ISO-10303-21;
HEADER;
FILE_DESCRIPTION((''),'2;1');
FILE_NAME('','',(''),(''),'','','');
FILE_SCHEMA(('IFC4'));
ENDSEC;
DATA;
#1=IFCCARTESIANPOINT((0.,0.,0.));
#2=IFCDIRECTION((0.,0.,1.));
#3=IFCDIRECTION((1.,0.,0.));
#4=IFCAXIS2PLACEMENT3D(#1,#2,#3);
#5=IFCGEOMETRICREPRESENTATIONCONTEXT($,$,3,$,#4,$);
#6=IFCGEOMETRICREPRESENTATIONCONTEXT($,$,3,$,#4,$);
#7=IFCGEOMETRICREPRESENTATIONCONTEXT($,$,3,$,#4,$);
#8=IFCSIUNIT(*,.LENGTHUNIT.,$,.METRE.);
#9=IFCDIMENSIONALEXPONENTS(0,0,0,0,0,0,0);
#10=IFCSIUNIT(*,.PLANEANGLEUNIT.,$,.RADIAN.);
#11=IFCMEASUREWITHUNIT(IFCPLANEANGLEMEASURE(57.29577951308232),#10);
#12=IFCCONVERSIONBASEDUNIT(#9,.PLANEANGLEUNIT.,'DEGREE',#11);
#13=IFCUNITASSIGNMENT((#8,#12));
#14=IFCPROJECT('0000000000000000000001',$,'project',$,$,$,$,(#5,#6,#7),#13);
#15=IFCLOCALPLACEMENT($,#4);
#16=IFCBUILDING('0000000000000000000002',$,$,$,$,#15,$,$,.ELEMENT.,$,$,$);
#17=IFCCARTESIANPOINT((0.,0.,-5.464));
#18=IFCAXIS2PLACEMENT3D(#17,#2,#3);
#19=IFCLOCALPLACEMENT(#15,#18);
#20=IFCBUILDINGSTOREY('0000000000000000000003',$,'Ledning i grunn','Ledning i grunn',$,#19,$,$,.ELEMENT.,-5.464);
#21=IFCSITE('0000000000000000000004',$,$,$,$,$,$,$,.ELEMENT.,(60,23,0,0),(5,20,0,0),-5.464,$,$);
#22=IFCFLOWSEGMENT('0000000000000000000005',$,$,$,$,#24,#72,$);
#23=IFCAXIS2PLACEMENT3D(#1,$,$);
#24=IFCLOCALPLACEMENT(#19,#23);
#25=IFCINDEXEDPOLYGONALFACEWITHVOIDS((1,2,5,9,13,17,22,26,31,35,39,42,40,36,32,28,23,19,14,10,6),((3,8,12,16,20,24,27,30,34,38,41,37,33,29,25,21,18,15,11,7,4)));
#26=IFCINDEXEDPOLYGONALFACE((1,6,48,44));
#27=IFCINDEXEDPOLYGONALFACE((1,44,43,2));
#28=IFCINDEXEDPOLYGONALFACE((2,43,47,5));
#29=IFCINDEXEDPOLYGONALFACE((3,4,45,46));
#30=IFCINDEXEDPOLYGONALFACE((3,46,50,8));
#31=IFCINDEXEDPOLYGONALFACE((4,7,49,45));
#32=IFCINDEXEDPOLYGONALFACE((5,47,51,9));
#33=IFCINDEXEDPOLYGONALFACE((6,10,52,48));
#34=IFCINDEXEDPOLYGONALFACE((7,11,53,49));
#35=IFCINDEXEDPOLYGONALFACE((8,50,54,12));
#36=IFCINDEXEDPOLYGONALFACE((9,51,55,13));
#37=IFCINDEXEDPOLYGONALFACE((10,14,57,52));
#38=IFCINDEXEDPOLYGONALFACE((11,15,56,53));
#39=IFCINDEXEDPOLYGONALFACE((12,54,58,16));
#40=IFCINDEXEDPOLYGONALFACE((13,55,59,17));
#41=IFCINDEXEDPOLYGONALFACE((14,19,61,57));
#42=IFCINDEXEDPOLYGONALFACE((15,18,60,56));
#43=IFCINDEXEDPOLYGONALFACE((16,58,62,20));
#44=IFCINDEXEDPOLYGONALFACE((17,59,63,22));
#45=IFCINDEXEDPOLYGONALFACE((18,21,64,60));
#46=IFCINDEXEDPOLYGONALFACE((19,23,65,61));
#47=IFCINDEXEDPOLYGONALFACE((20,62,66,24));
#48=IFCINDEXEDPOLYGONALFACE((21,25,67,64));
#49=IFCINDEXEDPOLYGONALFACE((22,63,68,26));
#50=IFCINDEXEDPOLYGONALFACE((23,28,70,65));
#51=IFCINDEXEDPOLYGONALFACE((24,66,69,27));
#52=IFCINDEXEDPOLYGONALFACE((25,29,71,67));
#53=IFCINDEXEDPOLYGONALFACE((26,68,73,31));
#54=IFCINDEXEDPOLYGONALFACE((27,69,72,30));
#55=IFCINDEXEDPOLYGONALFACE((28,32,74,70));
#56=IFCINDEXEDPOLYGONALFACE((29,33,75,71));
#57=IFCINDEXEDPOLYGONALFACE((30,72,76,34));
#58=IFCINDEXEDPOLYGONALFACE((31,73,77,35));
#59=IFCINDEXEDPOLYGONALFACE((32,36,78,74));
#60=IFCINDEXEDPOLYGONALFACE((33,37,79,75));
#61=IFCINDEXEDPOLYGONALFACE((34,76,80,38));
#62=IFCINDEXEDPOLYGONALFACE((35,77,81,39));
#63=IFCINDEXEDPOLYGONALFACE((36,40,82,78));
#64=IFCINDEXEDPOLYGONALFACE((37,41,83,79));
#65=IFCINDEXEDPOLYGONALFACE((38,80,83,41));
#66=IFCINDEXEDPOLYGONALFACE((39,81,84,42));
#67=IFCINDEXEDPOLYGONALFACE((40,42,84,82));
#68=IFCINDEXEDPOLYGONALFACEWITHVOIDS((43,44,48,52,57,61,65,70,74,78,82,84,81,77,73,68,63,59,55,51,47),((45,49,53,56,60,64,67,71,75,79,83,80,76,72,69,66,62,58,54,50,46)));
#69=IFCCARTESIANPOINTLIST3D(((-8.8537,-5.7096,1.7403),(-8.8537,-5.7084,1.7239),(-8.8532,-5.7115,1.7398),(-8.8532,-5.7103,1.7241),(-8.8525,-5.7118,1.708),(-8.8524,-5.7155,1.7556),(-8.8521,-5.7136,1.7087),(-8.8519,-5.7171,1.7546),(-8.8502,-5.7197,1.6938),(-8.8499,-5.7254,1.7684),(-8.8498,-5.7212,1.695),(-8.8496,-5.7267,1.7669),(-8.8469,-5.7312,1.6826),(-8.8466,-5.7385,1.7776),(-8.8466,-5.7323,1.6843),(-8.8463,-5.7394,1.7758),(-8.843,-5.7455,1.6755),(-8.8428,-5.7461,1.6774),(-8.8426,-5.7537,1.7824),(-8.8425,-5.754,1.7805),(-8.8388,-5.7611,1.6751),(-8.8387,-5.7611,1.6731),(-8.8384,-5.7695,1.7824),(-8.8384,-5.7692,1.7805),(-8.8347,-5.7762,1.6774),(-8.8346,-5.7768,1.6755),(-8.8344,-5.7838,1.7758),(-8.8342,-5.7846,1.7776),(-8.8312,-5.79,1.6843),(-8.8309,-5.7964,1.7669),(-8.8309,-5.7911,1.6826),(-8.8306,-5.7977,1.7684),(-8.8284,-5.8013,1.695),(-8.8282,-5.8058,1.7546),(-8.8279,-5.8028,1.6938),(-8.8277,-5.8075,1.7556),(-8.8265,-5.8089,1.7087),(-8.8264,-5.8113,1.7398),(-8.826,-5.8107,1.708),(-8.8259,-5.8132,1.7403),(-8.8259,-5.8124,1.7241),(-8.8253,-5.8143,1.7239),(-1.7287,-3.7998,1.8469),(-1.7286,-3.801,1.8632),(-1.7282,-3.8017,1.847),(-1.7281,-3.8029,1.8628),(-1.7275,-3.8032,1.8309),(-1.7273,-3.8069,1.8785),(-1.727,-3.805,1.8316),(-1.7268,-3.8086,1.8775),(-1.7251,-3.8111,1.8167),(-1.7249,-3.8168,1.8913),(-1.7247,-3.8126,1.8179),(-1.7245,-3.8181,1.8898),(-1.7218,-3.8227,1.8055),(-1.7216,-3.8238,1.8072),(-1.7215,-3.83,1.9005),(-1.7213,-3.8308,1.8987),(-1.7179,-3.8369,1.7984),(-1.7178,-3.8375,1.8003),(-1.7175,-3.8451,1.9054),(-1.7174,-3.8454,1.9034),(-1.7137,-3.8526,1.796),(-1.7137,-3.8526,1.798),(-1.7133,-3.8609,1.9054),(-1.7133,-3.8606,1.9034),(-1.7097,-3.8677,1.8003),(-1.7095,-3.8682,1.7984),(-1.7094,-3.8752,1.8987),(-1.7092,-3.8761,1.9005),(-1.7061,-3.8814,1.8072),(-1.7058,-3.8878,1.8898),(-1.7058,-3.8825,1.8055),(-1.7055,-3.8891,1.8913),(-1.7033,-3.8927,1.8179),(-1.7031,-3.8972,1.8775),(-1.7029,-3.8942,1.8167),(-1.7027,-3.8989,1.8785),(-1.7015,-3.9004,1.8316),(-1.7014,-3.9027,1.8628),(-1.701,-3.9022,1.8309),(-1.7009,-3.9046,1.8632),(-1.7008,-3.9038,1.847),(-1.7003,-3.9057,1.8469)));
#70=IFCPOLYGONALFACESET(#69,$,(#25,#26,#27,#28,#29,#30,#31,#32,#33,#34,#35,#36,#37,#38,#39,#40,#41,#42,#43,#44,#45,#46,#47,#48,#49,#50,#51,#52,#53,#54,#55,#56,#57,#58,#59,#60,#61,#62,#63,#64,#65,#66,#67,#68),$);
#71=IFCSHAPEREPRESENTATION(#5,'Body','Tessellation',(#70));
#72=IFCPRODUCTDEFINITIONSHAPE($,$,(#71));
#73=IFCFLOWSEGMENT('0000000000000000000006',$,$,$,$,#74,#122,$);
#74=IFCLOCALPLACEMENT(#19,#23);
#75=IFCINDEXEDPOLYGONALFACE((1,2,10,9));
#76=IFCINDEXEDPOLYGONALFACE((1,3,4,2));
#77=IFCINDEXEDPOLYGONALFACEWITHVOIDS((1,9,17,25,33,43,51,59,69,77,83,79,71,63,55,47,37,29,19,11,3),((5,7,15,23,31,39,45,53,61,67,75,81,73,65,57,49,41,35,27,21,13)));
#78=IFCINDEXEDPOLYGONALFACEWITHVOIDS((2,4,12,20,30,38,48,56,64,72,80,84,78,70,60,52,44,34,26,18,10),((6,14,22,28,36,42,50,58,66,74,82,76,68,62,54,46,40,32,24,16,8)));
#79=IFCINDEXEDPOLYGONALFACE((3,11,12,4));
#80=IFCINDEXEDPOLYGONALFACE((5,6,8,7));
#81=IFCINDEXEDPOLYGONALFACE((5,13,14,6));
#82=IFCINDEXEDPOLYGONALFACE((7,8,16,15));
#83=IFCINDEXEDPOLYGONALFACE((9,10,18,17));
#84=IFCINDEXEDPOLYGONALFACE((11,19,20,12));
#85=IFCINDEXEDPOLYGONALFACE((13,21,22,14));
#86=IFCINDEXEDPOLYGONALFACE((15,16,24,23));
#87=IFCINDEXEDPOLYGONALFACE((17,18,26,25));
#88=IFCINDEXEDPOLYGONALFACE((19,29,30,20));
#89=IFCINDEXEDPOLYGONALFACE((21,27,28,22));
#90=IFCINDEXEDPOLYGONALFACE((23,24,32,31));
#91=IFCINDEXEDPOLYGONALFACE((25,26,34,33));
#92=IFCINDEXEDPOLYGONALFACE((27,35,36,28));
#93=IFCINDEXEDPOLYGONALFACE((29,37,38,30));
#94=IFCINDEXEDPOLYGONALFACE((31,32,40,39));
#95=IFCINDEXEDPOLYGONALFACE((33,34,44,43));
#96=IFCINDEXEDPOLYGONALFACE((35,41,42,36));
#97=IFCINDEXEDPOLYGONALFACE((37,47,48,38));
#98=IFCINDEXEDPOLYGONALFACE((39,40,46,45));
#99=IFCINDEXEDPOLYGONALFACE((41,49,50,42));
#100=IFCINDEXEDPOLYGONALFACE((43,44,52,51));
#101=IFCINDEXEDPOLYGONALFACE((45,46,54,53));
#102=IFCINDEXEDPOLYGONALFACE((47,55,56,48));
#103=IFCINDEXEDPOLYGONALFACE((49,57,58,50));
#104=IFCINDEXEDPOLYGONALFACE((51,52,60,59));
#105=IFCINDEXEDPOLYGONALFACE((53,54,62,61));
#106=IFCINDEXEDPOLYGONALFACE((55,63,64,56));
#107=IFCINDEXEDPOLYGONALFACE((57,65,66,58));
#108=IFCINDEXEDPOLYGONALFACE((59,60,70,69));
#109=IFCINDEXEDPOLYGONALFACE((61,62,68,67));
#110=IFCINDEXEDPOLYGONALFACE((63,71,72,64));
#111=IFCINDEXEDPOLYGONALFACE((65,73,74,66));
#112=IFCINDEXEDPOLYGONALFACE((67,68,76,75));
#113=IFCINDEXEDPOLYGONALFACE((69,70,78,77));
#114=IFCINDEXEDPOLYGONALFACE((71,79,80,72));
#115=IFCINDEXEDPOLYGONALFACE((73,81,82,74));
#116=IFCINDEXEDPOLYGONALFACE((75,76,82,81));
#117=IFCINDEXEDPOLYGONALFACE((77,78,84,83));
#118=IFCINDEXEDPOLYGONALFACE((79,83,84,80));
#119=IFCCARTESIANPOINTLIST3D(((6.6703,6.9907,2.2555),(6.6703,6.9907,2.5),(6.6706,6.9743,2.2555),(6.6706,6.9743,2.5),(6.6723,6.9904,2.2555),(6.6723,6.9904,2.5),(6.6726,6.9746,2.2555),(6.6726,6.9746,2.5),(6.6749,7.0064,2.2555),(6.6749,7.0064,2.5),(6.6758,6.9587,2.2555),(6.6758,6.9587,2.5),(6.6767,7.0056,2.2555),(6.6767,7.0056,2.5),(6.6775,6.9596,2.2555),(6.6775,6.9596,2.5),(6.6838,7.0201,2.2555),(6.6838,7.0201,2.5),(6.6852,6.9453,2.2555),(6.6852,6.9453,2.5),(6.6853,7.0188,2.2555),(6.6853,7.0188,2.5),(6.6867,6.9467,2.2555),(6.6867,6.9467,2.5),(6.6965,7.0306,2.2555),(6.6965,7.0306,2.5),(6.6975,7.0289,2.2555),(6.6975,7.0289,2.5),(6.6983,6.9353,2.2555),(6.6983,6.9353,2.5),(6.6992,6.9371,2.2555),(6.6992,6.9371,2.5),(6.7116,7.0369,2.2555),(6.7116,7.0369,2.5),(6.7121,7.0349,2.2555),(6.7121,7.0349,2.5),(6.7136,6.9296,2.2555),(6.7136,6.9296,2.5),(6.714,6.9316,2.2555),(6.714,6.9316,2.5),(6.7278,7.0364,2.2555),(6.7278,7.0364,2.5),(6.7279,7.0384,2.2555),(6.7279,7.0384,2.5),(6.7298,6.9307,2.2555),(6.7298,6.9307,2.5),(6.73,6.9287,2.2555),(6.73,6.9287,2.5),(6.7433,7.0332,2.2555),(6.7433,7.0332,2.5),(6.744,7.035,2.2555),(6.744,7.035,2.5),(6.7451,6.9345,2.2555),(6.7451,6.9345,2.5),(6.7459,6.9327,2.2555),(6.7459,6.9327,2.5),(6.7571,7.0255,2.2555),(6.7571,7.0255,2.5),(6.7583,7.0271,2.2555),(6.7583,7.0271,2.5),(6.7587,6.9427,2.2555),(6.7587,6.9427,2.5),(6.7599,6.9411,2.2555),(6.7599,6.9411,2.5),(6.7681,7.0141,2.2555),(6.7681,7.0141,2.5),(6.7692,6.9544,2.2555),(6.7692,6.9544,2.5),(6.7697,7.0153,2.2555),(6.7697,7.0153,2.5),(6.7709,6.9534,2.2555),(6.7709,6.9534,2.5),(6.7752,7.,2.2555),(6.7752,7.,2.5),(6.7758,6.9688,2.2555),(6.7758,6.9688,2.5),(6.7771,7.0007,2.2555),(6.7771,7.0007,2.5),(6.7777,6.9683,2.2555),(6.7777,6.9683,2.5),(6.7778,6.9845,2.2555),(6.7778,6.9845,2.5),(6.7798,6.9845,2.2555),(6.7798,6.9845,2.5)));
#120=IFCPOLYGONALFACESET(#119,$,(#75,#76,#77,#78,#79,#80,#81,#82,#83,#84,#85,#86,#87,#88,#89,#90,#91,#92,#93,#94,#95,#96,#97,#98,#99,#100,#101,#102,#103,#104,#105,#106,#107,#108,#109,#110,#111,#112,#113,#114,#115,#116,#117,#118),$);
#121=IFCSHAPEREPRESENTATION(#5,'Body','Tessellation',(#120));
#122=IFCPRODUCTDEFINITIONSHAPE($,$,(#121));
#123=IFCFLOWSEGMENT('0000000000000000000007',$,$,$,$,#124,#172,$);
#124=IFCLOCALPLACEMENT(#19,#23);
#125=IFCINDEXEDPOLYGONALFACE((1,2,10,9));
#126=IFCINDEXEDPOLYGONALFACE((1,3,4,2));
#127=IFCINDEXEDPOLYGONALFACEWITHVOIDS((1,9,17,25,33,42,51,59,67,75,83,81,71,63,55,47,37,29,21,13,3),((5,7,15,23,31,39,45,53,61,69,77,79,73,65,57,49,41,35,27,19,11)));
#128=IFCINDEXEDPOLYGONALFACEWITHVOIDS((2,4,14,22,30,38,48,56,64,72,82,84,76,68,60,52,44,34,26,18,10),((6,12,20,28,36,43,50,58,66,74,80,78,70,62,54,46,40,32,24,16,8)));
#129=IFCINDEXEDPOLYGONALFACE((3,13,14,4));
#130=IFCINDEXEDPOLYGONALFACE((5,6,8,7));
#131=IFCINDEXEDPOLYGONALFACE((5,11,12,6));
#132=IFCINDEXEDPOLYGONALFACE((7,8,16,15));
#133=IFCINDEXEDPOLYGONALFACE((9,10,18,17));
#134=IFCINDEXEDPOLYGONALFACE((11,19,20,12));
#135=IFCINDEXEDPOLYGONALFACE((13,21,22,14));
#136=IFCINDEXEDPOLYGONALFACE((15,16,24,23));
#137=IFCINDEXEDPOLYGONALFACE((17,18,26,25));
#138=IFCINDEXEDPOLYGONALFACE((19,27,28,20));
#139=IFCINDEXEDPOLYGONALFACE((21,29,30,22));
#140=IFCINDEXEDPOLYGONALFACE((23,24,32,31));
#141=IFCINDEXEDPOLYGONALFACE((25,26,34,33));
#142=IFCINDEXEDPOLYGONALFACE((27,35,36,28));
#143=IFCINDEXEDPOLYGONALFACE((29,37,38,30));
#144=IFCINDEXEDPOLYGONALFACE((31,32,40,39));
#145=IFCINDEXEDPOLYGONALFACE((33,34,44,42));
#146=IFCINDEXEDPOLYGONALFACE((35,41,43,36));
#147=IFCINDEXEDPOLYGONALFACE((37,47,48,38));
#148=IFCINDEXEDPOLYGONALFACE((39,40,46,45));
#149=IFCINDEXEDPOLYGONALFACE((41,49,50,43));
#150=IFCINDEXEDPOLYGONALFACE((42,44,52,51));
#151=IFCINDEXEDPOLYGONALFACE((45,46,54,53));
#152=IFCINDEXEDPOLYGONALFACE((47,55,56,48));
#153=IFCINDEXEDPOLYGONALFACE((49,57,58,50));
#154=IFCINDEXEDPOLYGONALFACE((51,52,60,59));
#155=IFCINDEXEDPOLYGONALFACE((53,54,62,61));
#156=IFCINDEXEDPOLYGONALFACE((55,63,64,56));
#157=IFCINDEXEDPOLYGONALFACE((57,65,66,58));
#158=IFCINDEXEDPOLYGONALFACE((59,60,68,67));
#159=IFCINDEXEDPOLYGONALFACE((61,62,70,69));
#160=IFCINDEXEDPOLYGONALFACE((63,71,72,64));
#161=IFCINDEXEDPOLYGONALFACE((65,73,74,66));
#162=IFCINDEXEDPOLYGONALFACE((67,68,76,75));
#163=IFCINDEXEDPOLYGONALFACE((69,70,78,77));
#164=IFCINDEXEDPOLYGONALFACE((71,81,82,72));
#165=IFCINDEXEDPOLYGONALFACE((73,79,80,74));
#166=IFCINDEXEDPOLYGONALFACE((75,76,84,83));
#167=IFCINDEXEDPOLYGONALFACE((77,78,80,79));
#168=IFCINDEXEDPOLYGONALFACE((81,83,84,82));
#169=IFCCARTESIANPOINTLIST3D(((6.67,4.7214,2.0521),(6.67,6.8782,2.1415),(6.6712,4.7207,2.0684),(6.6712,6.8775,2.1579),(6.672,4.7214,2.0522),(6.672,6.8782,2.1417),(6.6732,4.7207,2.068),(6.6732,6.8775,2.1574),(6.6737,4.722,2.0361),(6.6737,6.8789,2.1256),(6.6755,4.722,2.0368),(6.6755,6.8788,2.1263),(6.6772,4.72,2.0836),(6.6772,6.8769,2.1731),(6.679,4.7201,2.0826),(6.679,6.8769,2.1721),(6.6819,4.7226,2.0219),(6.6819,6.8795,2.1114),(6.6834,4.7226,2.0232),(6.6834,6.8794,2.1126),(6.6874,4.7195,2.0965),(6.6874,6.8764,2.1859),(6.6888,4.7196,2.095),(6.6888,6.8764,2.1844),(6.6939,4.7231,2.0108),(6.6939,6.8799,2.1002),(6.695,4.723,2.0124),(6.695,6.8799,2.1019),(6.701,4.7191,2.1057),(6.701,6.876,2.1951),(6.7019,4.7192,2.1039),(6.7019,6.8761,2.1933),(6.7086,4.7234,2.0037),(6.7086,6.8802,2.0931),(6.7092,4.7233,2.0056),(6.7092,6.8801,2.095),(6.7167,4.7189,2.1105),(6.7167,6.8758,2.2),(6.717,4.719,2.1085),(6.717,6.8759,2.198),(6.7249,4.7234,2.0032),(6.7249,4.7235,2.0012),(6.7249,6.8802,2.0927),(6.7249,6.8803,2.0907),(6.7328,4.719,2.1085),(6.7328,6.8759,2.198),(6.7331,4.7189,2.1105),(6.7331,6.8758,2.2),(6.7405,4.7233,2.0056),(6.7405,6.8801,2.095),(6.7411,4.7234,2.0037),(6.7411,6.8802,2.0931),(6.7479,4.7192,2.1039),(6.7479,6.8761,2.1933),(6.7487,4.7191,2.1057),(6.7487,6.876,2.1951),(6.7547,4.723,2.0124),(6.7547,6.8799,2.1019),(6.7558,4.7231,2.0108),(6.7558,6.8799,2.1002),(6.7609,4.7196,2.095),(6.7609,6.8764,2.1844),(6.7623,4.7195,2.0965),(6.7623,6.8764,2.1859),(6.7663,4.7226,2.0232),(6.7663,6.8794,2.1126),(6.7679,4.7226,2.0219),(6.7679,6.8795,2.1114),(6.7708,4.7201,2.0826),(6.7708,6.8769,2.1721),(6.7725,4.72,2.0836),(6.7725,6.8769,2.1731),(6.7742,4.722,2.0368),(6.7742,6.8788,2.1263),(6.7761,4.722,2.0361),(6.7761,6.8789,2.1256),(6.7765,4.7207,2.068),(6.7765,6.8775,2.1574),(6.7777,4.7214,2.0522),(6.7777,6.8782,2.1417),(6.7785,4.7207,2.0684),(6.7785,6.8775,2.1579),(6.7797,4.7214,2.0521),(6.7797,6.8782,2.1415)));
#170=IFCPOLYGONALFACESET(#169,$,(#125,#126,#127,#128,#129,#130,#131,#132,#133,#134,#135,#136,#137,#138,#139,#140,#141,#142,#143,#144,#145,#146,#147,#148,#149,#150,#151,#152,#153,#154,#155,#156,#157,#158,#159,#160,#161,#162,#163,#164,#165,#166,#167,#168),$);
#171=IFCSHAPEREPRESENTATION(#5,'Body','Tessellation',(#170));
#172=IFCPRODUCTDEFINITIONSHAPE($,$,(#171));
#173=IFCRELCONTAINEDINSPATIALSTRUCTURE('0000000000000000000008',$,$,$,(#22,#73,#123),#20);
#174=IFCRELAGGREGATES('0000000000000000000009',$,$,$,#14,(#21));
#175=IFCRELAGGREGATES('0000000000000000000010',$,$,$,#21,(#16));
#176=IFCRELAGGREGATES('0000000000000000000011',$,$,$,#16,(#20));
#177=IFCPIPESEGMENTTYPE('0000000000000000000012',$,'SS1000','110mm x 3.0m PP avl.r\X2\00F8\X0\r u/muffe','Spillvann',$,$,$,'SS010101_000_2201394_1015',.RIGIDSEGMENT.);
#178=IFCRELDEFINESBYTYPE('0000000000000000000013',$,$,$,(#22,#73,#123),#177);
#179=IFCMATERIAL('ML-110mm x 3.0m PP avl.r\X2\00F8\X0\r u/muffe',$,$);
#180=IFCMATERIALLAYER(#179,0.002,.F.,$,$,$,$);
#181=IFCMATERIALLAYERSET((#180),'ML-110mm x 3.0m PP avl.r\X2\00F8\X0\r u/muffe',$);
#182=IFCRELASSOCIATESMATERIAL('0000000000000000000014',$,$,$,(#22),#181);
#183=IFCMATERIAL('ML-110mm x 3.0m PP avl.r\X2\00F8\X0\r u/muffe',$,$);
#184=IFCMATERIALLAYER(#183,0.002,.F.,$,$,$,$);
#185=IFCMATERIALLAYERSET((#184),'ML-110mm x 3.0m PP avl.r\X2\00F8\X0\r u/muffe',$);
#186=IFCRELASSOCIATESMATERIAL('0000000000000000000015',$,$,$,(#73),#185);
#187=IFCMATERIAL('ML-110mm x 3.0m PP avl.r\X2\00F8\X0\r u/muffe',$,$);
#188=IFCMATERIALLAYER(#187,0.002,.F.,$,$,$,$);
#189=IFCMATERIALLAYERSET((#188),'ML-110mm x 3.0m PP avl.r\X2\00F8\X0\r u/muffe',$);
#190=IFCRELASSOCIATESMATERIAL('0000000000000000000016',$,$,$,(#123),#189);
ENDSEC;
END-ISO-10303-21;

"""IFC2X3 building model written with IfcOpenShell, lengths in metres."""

from ifc_helpers import new_model, entity, si_unit, converted_unit, frame, origin_with_axes, origin_2d_with_axis, place, context, project, spatial, hollow_circle, extrude, material, layer, layer_set, layer_usage, type_object, element, save


model = new_model("IFC2X3")

# Units and contexts
context_of_model_1 = context(None, 3, world=origin_with_axes())
context_of_model_2 = context(None, 3, world=origin_with_axes())
context_of_model_3 = context(None, 3, world=origin_with_axes())
ifc_project = project(units=[si_unit("LENGTHUNIT", "METRE"), converted_unit("PLANEANGLEUNIT", "DEGREE", entity("IfcPlaneAngleMeasure", 57.29577951308232), si_unit("PLANEANGLEUNIT", "RADIAN"), dimensions=[0, 0, 0, 0, 0, 0, 0])], contexts=[context_of_model_1, context_of_model_2, context_of_model_3])

# Site, building, storey
site = spatial("IfcSite", under=ifc_project, CompositionType="ELEMENT", RefLatitude=(60, 23, 0, 0), RefLongitude=(5, 20, 0, 0), RefElevation=-5.464)
building_placement = place(None, origin_with_axes())
building = spatial("IfcBuilding", under=site, at=building_placement, CompositionType="ELEMENT")
storey_placement = place(building_placement, frame((0.0, 0.0, -5.464), z_axis=(0.0, 0.0, 1.0), x_axis=(1.0, 0.0, 0.0)))
storey = spatial("IfcBuildingStorey", under=building, at=storey_placement, Name="Ledning i grunn", Description="Ledning i grunn", CompositionType="ELEMENT", Elevation=-5.464)

# Flow segments
pipe_segment_type_1 = type_object("IfcPipeSegmentType", Name="SS1000", Description="110mm x 3.0m PP avl.rør u/muffe", ApplicableOccurrence="Spillvann", ElementType="SS010101_000_2201394_1015", PredefinedType="RIGIDSEGMENT")
ifc_material_1 = material(Name="ML-110mm x 3.0m PP avl.rør u/muffe")
ifc_layer_1 = layer(ifc_material_1, 0.002, ventilated=False)
ifc_layer_set_1 = layer_set([ifc_layer_1], Name="ML-110mm x 3.0m PP avl.rør u/muffe")
ifc_layer_usage_1 = layer_usage(ifc_layer_set_1, "AXIS2", "POSITIVE", 0.0)
flow_segment_1_placement = place(storey_placement, frame((-1.7145, -3.8528, 1.851), z_axis=(-0.965811, -0.258711, -0.016661), x_axis=(0.016094, 0.004311, -0.999861)))
element("IfcFlowSegment", 1, at=flow_segment_1_placement, inside=storey, type_object=pipe_segment_type_1, material=ifc_layer_usage_1, context=context_of_model_1, shape_type="SweptSolid", body=[
    extrude(hollow_circle(Radius=0.055, WallThickness=0.002, at=origin_2d_with_axis()), origin_with_axes(), (0.0, 0.0, 1.0), 7.3773),
])
ifc_material_2 = material(Name="ML-110mm x 3.0m PP avl.rør u/muffe")
ifc_layer_2 = layer(ifc_material_2, 0.002, ventilated=False)
ifc_layer_set_2 = layer_set([ifc_layer_2], Name="ML-110mm x 3.0m PP avl.rør u/muffe")
ifc_layer_usage_2 = layer_usage(ifc_layer_set_2, "AXIS2", "POSITIVE", 0.0)
flow_segment_2_placement = place(storey_placement, frame((6.7249, 6.9835, 2.5), z_axis=(0.0, 0.0, -1.0), x_axis=(0.382683, -0.92388, 0.0)))
element("IfcFlowSegment", 2, at=flow_segment_2_placement, inside=storey, type_object=pipe_segment_type_1, material=ifc_layer_usage_2, context=context_of_model_1, shape_type="SweptSolid", body=[
    extrude(hollow_circle(Radius=0.055, WallThickness=0.002, at=origin_2d_with_axis()), origin_with_axes(), (0.0, 0.0, 1.0), 0.2445),
])
ifc_material_3 = material(Name="ML-110mm x 3.0m PP avl.rør u/muffe")
ifc_layer_3 = layer(ifc_material_3, 0.002, ventilated=False)
ifc_layer_set_3 = layer_set([ifc_layer_3], Name="ML-110mm x 3.0m PP avl.rør u/muffe")
ifc_layer_usage_3 = layer_usage(ifc_layer_set_3, "AXIS2", "POSITIVE", 0.0)
flow_segment_3_placement = place(storey_placement, frame((6.7249, 6.878, 2.1456), z_axis=(0.000001, -0.999141, -0.04144), x_axis=(0.0, 0.04144, -0.999141)))
element("IfcFlowSegment", 3, at=flow_segment_3_placement, inside=storey, type_object=pipe_segment_type_1, material=ifc_layer_usage_3, context=context_of_model_1, shape_type="SweptSolid", body=[
    extrude(hollow_circle(Radius=0.055, WallThickness=0.002, at=origin_2d_with_axis()), origin_with_axes(), (0.0, 0.0, 1.0), 2.1587),
])

save(model, "model.ifc")
